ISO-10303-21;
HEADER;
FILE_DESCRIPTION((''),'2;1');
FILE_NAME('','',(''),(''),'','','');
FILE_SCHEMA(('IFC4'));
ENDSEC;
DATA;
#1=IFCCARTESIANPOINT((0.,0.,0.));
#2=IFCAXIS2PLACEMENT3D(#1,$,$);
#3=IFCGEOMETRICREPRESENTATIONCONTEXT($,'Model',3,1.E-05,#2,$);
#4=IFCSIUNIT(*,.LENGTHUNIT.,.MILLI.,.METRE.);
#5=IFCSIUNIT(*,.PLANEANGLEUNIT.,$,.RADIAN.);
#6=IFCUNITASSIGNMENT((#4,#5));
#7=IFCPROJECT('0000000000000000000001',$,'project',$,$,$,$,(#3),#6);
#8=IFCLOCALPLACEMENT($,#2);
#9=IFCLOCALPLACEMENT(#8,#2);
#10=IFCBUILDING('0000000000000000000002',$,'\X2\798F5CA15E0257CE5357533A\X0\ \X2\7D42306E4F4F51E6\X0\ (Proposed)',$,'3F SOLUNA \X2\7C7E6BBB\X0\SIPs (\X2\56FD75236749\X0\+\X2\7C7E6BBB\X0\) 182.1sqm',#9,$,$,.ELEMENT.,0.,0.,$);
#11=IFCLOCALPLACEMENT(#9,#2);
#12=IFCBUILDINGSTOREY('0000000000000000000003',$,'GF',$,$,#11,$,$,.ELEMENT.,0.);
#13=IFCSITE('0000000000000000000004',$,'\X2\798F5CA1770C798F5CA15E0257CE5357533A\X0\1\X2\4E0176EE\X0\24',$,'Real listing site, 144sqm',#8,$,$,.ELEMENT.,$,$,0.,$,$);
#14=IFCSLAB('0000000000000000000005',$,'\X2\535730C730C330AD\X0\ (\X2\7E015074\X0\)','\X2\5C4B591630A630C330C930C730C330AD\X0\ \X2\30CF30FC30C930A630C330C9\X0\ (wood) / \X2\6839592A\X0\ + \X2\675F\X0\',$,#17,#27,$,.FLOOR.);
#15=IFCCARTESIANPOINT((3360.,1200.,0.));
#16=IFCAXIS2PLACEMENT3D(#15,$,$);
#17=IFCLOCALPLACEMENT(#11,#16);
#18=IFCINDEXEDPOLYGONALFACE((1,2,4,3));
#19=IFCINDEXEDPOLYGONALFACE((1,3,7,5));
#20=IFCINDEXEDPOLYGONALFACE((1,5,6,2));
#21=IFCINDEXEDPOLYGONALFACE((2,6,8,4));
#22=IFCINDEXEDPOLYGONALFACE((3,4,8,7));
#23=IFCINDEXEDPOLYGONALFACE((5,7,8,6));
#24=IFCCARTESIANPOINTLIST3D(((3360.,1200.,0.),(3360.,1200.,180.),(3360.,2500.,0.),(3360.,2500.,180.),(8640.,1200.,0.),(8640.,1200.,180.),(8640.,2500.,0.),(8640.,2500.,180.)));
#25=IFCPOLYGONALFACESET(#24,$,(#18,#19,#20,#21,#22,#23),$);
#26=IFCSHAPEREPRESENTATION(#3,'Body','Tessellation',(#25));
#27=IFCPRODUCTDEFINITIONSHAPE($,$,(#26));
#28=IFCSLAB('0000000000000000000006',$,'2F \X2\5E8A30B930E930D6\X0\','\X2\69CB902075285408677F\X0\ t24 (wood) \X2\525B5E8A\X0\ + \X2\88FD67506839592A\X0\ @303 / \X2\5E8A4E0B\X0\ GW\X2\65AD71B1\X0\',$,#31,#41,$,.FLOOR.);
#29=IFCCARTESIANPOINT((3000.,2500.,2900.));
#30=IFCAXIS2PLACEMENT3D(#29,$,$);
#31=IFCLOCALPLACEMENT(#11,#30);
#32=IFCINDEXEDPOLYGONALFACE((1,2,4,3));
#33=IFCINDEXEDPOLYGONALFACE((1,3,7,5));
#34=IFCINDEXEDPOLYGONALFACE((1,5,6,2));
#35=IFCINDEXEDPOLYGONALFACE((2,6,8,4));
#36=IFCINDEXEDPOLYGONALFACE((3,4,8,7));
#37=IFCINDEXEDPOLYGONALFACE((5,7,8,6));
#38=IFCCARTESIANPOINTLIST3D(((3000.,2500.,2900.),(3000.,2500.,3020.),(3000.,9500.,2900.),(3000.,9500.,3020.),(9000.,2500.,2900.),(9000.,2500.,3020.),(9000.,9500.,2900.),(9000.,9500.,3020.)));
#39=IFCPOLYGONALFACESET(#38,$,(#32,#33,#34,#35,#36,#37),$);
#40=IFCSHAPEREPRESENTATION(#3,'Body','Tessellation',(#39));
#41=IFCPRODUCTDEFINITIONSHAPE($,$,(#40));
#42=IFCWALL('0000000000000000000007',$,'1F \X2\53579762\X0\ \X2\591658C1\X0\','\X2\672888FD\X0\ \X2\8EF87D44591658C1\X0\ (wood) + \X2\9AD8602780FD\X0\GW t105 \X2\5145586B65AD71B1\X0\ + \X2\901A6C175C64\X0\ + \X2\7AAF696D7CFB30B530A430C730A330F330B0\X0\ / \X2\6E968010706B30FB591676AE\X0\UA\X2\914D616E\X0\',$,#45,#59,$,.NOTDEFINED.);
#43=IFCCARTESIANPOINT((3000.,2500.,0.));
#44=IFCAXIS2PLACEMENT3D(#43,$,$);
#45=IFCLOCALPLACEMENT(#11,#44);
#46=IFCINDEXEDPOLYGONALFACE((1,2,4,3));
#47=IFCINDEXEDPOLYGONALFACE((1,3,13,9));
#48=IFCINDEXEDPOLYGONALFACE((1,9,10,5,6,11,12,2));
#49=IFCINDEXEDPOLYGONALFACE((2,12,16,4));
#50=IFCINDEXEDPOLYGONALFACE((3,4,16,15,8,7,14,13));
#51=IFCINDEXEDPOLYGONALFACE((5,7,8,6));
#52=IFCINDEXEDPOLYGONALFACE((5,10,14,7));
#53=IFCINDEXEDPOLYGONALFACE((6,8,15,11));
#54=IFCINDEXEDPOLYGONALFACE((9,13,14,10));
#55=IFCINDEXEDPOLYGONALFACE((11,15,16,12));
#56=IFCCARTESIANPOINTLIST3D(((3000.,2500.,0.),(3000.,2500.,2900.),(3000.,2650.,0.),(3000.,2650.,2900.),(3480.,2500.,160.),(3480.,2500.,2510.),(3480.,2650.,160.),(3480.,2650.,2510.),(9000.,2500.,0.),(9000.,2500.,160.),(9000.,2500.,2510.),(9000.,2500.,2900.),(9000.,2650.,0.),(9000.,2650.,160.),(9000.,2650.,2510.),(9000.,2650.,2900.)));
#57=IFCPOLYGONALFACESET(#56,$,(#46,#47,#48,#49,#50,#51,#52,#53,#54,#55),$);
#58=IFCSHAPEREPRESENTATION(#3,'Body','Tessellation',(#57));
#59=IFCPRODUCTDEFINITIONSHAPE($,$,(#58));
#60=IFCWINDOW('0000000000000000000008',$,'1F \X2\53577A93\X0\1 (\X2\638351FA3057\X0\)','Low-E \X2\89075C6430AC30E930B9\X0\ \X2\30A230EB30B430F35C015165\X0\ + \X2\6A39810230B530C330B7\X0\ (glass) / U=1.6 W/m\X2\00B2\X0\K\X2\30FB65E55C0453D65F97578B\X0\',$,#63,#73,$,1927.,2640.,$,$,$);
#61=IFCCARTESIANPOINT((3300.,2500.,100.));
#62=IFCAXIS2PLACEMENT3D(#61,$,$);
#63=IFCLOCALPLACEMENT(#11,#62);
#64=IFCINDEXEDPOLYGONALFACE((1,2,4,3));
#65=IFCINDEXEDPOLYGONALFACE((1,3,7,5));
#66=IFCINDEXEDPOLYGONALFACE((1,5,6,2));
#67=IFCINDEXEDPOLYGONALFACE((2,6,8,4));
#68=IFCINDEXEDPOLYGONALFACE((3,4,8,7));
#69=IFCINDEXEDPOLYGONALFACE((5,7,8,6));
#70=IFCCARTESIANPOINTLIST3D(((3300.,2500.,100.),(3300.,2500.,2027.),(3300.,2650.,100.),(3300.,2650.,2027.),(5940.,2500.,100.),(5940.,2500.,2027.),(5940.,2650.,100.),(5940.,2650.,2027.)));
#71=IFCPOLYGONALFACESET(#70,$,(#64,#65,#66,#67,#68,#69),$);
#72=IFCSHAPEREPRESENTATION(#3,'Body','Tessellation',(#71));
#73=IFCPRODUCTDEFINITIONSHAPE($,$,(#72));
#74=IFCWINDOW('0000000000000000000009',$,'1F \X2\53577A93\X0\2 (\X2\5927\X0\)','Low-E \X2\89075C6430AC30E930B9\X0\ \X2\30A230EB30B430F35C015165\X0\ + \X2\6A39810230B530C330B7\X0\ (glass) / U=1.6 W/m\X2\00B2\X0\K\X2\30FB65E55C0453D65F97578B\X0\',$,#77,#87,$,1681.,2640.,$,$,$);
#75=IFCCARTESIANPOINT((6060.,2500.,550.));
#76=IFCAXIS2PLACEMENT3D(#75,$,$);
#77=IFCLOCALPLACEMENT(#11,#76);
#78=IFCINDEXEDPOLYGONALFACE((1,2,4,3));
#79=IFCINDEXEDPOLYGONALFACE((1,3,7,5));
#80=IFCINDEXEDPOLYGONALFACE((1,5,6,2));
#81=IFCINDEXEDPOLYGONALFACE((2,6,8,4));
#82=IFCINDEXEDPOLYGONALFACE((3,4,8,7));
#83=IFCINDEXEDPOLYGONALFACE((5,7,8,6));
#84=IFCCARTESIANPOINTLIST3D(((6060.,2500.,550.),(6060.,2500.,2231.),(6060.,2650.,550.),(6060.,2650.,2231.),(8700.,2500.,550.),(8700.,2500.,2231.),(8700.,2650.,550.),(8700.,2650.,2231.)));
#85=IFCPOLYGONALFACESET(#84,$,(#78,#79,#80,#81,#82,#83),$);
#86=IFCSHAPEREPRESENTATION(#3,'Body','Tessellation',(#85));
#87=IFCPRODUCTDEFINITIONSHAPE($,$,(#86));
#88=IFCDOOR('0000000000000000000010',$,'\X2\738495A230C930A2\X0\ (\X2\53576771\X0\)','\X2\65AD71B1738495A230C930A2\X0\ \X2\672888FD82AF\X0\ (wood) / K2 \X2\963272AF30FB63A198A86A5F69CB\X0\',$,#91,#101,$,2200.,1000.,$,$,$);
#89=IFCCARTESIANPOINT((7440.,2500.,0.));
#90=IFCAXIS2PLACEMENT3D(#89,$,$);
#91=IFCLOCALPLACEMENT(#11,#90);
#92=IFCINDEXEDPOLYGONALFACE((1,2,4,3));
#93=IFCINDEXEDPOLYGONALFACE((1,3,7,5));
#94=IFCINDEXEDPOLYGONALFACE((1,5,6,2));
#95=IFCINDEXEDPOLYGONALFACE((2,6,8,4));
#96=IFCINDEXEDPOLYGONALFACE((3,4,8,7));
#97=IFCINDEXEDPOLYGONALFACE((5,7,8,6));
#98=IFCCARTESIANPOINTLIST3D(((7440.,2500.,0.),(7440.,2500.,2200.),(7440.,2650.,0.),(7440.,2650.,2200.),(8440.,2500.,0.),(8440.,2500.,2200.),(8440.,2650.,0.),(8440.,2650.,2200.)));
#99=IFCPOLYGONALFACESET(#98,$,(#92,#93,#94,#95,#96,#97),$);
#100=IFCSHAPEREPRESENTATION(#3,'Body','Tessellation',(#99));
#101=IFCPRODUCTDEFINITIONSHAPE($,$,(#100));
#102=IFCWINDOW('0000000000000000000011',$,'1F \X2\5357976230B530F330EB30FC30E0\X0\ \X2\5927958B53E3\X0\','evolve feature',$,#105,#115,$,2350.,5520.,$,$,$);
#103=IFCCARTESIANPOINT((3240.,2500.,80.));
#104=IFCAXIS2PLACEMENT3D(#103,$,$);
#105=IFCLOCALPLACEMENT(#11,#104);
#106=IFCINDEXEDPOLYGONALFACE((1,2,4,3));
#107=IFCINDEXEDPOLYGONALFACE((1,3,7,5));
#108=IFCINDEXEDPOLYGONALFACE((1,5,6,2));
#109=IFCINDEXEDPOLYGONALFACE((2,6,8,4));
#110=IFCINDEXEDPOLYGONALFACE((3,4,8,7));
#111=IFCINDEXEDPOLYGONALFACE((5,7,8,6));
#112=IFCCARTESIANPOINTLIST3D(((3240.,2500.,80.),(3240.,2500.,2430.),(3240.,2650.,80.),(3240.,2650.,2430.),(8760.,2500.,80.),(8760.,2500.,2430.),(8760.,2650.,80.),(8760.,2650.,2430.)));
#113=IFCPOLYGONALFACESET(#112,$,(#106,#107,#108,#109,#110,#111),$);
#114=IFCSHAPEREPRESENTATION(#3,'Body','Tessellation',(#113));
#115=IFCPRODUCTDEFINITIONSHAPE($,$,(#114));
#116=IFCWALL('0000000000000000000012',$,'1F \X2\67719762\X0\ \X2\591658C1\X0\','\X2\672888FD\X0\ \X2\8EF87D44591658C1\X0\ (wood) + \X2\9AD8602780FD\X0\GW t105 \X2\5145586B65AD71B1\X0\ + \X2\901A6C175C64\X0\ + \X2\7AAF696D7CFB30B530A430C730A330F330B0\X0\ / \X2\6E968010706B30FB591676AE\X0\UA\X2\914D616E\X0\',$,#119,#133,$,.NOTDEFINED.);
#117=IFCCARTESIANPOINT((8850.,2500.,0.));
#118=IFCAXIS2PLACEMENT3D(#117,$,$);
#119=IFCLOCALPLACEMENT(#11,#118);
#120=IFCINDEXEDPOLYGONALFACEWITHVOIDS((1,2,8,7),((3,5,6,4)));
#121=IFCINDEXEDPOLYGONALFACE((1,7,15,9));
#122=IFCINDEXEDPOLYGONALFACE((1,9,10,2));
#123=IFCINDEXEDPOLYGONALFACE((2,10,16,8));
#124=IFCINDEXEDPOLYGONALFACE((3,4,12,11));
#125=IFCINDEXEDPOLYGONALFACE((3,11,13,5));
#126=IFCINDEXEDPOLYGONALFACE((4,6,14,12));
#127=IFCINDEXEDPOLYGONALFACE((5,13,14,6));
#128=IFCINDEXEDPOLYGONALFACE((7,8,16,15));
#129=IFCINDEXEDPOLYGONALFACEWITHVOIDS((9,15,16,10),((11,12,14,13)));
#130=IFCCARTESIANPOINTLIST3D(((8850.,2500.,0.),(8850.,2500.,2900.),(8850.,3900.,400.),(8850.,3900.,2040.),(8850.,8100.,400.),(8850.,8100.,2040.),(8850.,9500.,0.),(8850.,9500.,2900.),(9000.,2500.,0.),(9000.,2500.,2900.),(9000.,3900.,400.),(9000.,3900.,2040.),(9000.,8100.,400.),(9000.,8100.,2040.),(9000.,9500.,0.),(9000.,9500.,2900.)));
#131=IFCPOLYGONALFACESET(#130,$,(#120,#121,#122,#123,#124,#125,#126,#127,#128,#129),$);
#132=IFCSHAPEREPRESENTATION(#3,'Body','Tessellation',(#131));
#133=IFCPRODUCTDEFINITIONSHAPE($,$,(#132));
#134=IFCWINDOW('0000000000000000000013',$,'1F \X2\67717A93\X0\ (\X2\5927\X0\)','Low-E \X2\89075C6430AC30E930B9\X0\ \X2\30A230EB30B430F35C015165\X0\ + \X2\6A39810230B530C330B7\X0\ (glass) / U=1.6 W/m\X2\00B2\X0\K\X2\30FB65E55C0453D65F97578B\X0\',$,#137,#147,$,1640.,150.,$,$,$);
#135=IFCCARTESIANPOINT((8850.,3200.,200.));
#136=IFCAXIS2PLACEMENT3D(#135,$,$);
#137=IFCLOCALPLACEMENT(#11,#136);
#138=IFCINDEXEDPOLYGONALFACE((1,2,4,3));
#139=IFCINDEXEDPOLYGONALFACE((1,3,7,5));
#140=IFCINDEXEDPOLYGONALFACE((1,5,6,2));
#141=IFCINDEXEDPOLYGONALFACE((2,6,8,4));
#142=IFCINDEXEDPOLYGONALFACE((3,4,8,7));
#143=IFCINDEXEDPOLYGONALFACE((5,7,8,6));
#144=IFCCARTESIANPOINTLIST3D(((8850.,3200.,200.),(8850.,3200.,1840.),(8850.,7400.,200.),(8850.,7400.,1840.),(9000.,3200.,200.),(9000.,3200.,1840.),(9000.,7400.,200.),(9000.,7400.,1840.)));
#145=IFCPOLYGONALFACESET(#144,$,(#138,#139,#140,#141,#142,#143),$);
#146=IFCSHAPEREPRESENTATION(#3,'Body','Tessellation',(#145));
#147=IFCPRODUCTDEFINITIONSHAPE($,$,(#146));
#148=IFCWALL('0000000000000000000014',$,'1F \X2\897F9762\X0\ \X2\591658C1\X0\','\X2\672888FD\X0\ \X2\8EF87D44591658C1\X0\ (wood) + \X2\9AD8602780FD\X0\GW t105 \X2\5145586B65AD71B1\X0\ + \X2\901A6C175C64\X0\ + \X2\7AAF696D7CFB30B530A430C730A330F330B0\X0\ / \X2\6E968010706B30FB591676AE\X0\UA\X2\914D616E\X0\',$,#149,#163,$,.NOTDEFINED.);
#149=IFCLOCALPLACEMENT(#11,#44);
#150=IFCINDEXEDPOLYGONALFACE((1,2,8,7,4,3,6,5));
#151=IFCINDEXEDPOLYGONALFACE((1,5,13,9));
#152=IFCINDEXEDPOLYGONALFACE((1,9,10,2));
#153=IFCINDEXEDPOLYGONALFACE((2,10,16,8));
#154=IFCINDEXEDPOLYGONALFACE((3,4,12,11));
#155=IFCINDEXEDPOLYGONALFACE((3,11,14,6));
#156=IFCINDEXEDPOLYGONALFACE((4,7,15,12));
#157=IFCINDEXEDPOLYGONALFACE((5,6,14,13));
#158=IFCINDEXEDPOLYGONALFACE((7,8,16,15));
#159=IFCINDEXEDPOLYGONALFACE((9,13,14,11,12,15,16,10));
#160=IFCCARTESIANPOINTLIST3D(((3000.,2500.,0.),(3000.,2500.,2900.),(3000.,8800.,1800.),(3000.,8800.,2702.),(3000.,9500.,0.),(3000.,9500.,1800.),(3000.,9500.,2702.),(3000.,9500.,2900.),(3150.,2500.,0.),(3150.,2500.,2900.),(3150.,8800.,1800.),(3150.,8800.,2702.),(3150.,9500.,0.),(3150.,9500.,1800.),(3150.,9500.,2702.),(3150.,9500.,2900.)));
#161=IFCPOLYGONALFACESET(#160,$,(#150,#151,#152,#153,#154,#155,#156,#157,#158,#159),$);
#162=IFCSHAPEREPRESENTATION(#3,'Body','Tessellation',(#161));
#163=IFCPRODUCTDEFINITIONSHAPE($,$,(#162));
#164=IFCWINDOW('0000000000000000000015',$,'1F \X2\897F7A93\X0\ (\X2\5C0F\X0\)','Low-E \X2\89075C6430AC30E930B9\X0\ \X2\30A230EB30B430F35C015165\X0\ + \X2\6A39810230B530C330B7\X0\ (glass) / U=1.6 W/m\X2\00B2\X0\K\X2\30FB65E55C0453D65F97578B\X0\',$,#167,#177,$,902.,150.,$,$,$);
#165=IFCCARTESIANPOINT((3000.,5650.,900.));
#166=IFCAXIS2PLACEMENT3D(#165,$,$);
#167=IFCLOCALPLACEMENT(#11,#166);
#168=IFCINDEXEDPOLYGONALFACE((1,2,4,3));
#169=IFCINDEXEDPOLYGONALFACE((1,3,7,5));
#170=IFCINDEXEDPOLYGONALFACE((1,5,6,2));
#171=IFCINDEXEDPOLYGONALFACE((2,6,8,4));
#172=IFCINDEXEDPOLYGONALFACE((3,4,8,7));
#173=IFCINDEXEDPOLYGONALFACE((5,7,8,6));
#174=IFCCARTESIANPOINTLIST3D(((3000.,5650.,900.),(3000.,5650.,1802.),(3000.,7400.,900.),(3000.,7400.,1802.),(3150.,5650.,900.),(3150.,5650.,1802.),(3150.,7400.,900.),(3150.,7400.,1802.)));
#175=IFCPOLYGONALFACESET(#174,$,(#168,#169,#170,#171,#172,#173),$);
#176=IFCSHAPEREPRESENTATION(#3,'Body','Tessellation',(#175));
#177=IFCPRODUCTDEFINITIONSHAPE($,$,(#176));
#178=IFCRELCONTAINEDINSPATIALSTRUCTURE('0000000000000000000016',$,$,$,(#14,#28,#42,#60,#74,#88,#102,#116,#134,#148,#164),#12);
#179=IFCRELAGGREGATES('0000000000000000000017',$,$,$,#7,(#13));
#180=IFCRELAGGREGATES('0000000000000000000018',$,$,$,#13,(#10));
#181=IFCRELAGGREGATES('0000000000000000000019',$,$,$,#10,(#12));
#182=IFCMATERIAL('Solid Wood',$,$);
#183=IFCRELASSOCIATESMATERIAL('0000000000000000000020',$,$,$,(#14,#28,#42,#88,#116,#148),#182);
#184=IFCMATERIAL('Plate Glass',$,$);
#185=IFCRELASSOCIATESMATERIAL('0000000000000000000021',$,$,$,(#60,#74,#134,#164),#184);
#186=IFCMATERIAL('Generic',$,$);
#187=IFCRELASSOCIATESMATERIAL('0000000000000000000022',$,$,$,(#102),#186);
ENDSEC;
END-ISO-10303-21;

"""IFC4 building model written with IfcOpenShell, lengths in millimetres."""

from ifc_helpers import new_model, si_unit, frame, frame_2d, origin, place, context, project, spatial, rectangle, extrude, material, element, fill, save


model = new_model("IFC4")

# Units and contexts
model_context = context("Model", 3, precision=1e-05, world=origin())
ifc_project = project(units=[si_unit("LENGTHUNIT", "METRE", prefix="MILLI"), si_unit("PLANEANGLEUNIT", "RADIAN")], contexts=[model_context])

# Site, building, storey
site_placement = place(None, origin())
site = spatial("IfcSite", under=ifc_project, at=site_placement, Name="福岡県福岡市城南区1丁目24", ObjectType="Real listing site, 144sqm", CompositionType="ELEMENT", RefElevation=0.0)
building_placement = place(site_placement, origin())
building = spatial("IfcBuilding", under=site, at=building_placement, Name="福岡市城南区 終の住処 (Proposed)", ObjectType="3F SOLUNA 籾殻SIPs (国産杉+籾殻) 182.1sqm", CompositionType="ELEMENT", ElevationOfRefHeight=0.0, ElevationOfTerrain=0.0)
storey_placement = place(building_placement, origin())
storey = spatial("IfcBuildingStorey", under=building, at=storey_placement, Name="GF", CompositionType="ELEMENT", Elevation=0.0)

# Slabs
ifc_material_1 = material(Name="Solid Wood")
slab_1_placement = place(storey_placement, frame((3360.0, 1200.0, 0.0)))
element("IfcSlab", 1, at=slab_1_placement, inside=storey, material=ifc_material_1, Name="南デッキ (縁側)", Description="屋外ウッドデッキ ハードウッド (wood) / 根太 + 束", PredefinedType="FLOOR", context=model_context, shape_type="SweptSolid", body=[
    extrude(rectangle(XDim=5280.0, YDim=1300.0, at=frame_2d((2640.0, 650.0))), frame((3360.0, 1200.0, 0.0)), (0.0, 0.0, 1.0), 180.0),
])
slab_2_placement = place(storey_placement, frame((3000.0, 2500.0, 2900.0)))
element("IfcSlab", 2, at=slab_2_placement, inside=storey, material=ifc_material_1, Name="2F 床スラブ", Description="構造用合板 t24 (wood) 剛床 + 製材根太 @303 / 床下 GW断熱", PredefinedType="FLOOR", context=model_context, shape_type="SweptSolid", body=[
    extrude(rectangle(XDim=6000.0, YDim=7000.0, at=frame_2d((3000.0, 3500.0))), frame((3000.0, 2500.0, 2900.0)), (0.0, 0.0, 1.0), 120.0),
])

# Wall, openings, windows, door
wall_1_placement = place(storey_placement, frame((3000.0, 2500.0, 0.0)))
wall_1 = element("IfcWall", 3, at=wall_1_placement, inside=storey, material=ifc_material_1, Name="1F 南面 外壁", Description="木製 軸組外壁 (wood) + 高性能GW t105 充填断熱 + 通気層 + 窯業系サイディング / 準耐火・外皮UA配慮", PredefinedType="NOTDEFINED", context=model_context, shape_type="SweptSolid", body=[
    extrude(rectangle(XDim=6000.0, YDim=150.0, at=frame_2d((3000.0, 75.0))), frame((3000.0, 2500.0, 0.0)), (0.0, 0.0, 1.0), 2900.0),
])
opening_1_placement = place(storey_placement, frame((3300.0, 2500.0, 100.0)))
opening_1 = element("IfcOpeningElement", 4, at=opening_1_placement, cuts=wall_1, PredefinedType="NOTDEFINED", context=model_context, shape_type="SweptSolid", body=[
    extrude(rectangle(XDim=2640.0, YDim=150.0, at=frame_2d((1320.0, 75.0))), frame((3300.0, 2500.0, 100.0)), (0.0, 0.0, 1.0), 1927.0),
])
opening_2_placement = place(storey_placement, frame((6060.0, 2500.0, 550.0)))
opening_2 = element("IfcOpeningElement", 5, at=opening_2_placement, cuts=wall_1, PredefinedType="NOTDEFINED", context=model_context, shape_type="SweptSolid", body=[
    extrude(rectangle(XDim=2640.0, YDim=150.0, at=frame_2d((1320.0, 75.0))), frame((6060.0, 2500.0, 550.0)), (0.0, 0.0, 1.0), 1681.0),
])
opening_3_placement = place(storey_placement, frame((7440.0, 2500.0, 0.0)))
opening_3 = element("IfcOpeningElement", 6, at=opening_3_placement, cuts=wall_1, PredefinedType="NOTDEFINED", context=model_context, shape_type="SweptSolid", body=[
    extrude(rectangle(XDim=1000.0, YDim=150.0, at=frame_2d((500.0, 75.0))), frame((7440.0, 2500.0, 0.0)), (0.0, 0.0, 1.0), 2200.0),
])
opening_4_placement = place(storey_placement, frame((3240.0, 2500.0, 80.0)))
opening_4 = element("IfcOpeningElement", 7, at=opening_4_placement, cuts=wall_1, PredefinedType="NOTDEFINED", context=model_context, shape_type="SweptSolid", body=[
    extrude(rectangle(XDim=5520.0, YDim=150.0, at=frame_2d((2760.0, 75.0))), frame((3240.0, 2500.0, 80.0)), (0.0, 0.0, 1.0), 2350.0),
])
ifc_material_2 = material(Name="Plate Glass")
window_1_placement = place(storey_placement, frame((3300.0, 2500.0, 100.0)))
window_1 = element("IfcWindow", 8, at=window_1_placement, inside=storey, material=ifc_material_2, Name="1F 南窓1 (掃出し)", Description="Low-E 複層ガラス アルゴン封入 + 樹脂サッシ (glass) / U=1.6 W/m²K・日射取得型", OverallHeight=1927.0, OverallWidth=2640.0, context=model_context, shape_type="SweptSolid", body=[
    extrude(rectangle(XDim=2640.0, YDim=150.0, at=frame_2d((1320.0, 75.0))), frame((3300.0, 2500.0, 100.0)), (0.0, 0.0, 1.0), 1927.0),
])
fill(opening_1, window_1)
window_2_placement = place(storey_placement, frame((6060.0, 2500.0, 550.0)))
window_2 = element("IfcWindow", 9, at=window_2_placement, inside=storey, material=ifc_material_2, Name="1F 南窓2 (大)", Description="Low-E 複層ガラス アルゴン封入 + 樹脂サッシ (glass) / U=1.6 W/m²K・日射取得型", OverallHeight=1681.0, OverallWidth=2640.0, context=model_context, shape_type="SweptSolid", body=[
    extrude(rectangle(XDim=2640.0, YDim=150.0, at=frame_2d((1320.0, 75.0))), frame((6060.0, 2500.0, 550.0)), (0.0, 0.0, 1.0), 1681.0),
])
fill(opening_2, window_2)
door_placement = place(storey_placement, frame((7440.0, 2500.0, 0.0)))
door = element("IfcDoor", 10, at=door_placement, inside=storey, material=ifc_material_1, Name="玄関ドア (南東)", Description="断熱玄関ドア 木製芯 (wood) / K2 防犯・採風機構", OverallHeight=2200.0, OverallWidth=1000.0, context=model_context, shape_type="SweptSolid", body=[
    extrude(rectangle(XDim=1000.0, YDim=150.0, at=frame_2d((500.0, 75.0))), frame((7440.0, 2500.0, 0.0)), (0.0, 0.0, 1.0), 2200.0),
])
fill(opening_3, door)
ifc_material_3 = material(Name="Generic")
window_3_placement = place(storey_placement, frame((3240.0, 2500.0, 80.0)))
window_3 = element("IfcWindow", 11, at=window_3_placement, inside=storey, material=ifc_material_3, Name="1F 南面サンルーム 大開口", Description="evolve feature", OverallHeight=2350.0, OverallWidth=5520.0, context=model_context, shape_type="SweptSolid", body=[
    extrude(rectangle(XDim=5520.0, YDim=150.0, at=frame_2d((2760.0, 75.0))), frame((3240.0, 2500.0, 80.0)), (0.0, 0.0, 1.0), 2350.0),
])
fill(opening_4, window_3)

# Walls, openings, windows
wall_2_placement = place(storey_placement, frame((8850.0, 2500.0, 0.0)))
wall_2 = element("IfcWall", 12, at=wall_2_placement, inside=storey, material=ifc_material_1, Name="1F 東面 外壁", Description="木製 軸組外壁 (wood) + 高性能GW t105 充填断熱 + 通気層 + 窯業系サイディング / 準耐火・外皮UA配慮", PredefinedType="NOTDEFINED", context=model_context, shape_type="SweptSolid", body=[
    extrude(rectangle(XDim=150.0, YDim=7000.0, at=frame_2d((75.0, 3500.0))), frame((8850.0, 2500.0, 0.0)), (0.0, 0.0, 1.0), 2900.0),
])
opening_5_placement = place(storey_placement, frame((8850.0, 3200.0, 200.0)))
opening_5 = element("IfcOpeningElement", 13, at=opening_5_placement, cuts=wall_2, PredefinedType="NOTDEFINED", context=model_context, shape_type="SweptSolid", body=[
    extrude(rectangle(XDim=150.0, YDim=4200.0, at=frame_2d((75.0, 2100.0))), frame((8850.0, 3200.0, 200.0)), (0.0, 0.0, 1.0), 1640.0),
])
window_4_placement = place(storey_placement, frame((8850.0, 3200.0, 200.0)))
window_4 = element("IfcWindow", 14, at=window_4_placement, inside=storey, material=ifc_material_2, Name="1F 東窓 (大)", Description="Low-E 複層ガラス アルゴン封入 + 樹脂サッシ (glass) / U=1.6 W/m²K・日射取得型", OverallHeight=1640.0, OverallWidth=150.0, context=model_context, shape_type="SweptSolid", body=[
    extrude(rectangle(XDim=150.0, YDim=4200.0, at=frame_2d((75.0, 2100.0))), frame((8850.0, 3200.0, 200.0)), (0.0, 0.0, 1.0), 1640.0),
])
fill(opening_5, window_4)
wall_3_placement = place(storey_placement, frame((3000.0, 2500.0, 0.0)))
wall_3 = element("IfcWall", 15, at=wall_3_placement, inside=storey, material=ifc_material_1, Name="1F 西面 外壁", Description="木製 軸組外壁 (wood) + 高性能GW t105 充填断熱 + 通気層 + 窯業系サイディング / 準耐火・外皮UA配慮", PredefinedType="NOTDEFINED", context=model_context, shape_type="SweptSolid", body=[
    extrude(rectangle(XDim=150.0, YDim=7000.0, at=frame_2d((75.0, 3500.0))), frame((3000.0, 2500.0, 0.0)), (0.0, 0.0, 1.0), 2900.0),
])
opening_6_placement = place(storey_placement, frame((3000.0, 5650.0, 900.0)))
opening_6 = element("IfcOpeningElement", 16, at=opening_6_placement, cuts=wall_3, PredefinedType="NOTDEFINED", context=model_context, shape_type="SweptSolid", body=[
    extrude(rectangle(XDim=150.0, YDim=1750.0, at=frame_2d((75.0, 875.0))), frame((3000.0, 5650.0, 900.0)), (0.0, 0.0, 1.0), 902.0),
])
window_5_placement = place(storey_placement, frame((3000.0, 5650.0, 900.0)))
window_5 = element("IfcWindow", 17, at=window_5_placement, inside=storey, material=ifc_material_2, Name="1F 西窓 (小)", Description="Low-E 複層ガラス アルゴン封入 + 樹脂サッシ (glass) / U=1.6 W/m²K・日射取得型", OverallHeight=902.0, OverallWidth=150.0, context=model_context, shape_type="SweptSolid", body=[
    extrude(rectangle(XDim=150.0, YDim=1750.0, at=frame_2d((75.0, 875.0))), frame((3000.0, 5650.0, 900.0)), (0.0, 0.0, 1.0), 902.0),
])
fill(opening_6, window_5)

save(model, "model.ifc")
